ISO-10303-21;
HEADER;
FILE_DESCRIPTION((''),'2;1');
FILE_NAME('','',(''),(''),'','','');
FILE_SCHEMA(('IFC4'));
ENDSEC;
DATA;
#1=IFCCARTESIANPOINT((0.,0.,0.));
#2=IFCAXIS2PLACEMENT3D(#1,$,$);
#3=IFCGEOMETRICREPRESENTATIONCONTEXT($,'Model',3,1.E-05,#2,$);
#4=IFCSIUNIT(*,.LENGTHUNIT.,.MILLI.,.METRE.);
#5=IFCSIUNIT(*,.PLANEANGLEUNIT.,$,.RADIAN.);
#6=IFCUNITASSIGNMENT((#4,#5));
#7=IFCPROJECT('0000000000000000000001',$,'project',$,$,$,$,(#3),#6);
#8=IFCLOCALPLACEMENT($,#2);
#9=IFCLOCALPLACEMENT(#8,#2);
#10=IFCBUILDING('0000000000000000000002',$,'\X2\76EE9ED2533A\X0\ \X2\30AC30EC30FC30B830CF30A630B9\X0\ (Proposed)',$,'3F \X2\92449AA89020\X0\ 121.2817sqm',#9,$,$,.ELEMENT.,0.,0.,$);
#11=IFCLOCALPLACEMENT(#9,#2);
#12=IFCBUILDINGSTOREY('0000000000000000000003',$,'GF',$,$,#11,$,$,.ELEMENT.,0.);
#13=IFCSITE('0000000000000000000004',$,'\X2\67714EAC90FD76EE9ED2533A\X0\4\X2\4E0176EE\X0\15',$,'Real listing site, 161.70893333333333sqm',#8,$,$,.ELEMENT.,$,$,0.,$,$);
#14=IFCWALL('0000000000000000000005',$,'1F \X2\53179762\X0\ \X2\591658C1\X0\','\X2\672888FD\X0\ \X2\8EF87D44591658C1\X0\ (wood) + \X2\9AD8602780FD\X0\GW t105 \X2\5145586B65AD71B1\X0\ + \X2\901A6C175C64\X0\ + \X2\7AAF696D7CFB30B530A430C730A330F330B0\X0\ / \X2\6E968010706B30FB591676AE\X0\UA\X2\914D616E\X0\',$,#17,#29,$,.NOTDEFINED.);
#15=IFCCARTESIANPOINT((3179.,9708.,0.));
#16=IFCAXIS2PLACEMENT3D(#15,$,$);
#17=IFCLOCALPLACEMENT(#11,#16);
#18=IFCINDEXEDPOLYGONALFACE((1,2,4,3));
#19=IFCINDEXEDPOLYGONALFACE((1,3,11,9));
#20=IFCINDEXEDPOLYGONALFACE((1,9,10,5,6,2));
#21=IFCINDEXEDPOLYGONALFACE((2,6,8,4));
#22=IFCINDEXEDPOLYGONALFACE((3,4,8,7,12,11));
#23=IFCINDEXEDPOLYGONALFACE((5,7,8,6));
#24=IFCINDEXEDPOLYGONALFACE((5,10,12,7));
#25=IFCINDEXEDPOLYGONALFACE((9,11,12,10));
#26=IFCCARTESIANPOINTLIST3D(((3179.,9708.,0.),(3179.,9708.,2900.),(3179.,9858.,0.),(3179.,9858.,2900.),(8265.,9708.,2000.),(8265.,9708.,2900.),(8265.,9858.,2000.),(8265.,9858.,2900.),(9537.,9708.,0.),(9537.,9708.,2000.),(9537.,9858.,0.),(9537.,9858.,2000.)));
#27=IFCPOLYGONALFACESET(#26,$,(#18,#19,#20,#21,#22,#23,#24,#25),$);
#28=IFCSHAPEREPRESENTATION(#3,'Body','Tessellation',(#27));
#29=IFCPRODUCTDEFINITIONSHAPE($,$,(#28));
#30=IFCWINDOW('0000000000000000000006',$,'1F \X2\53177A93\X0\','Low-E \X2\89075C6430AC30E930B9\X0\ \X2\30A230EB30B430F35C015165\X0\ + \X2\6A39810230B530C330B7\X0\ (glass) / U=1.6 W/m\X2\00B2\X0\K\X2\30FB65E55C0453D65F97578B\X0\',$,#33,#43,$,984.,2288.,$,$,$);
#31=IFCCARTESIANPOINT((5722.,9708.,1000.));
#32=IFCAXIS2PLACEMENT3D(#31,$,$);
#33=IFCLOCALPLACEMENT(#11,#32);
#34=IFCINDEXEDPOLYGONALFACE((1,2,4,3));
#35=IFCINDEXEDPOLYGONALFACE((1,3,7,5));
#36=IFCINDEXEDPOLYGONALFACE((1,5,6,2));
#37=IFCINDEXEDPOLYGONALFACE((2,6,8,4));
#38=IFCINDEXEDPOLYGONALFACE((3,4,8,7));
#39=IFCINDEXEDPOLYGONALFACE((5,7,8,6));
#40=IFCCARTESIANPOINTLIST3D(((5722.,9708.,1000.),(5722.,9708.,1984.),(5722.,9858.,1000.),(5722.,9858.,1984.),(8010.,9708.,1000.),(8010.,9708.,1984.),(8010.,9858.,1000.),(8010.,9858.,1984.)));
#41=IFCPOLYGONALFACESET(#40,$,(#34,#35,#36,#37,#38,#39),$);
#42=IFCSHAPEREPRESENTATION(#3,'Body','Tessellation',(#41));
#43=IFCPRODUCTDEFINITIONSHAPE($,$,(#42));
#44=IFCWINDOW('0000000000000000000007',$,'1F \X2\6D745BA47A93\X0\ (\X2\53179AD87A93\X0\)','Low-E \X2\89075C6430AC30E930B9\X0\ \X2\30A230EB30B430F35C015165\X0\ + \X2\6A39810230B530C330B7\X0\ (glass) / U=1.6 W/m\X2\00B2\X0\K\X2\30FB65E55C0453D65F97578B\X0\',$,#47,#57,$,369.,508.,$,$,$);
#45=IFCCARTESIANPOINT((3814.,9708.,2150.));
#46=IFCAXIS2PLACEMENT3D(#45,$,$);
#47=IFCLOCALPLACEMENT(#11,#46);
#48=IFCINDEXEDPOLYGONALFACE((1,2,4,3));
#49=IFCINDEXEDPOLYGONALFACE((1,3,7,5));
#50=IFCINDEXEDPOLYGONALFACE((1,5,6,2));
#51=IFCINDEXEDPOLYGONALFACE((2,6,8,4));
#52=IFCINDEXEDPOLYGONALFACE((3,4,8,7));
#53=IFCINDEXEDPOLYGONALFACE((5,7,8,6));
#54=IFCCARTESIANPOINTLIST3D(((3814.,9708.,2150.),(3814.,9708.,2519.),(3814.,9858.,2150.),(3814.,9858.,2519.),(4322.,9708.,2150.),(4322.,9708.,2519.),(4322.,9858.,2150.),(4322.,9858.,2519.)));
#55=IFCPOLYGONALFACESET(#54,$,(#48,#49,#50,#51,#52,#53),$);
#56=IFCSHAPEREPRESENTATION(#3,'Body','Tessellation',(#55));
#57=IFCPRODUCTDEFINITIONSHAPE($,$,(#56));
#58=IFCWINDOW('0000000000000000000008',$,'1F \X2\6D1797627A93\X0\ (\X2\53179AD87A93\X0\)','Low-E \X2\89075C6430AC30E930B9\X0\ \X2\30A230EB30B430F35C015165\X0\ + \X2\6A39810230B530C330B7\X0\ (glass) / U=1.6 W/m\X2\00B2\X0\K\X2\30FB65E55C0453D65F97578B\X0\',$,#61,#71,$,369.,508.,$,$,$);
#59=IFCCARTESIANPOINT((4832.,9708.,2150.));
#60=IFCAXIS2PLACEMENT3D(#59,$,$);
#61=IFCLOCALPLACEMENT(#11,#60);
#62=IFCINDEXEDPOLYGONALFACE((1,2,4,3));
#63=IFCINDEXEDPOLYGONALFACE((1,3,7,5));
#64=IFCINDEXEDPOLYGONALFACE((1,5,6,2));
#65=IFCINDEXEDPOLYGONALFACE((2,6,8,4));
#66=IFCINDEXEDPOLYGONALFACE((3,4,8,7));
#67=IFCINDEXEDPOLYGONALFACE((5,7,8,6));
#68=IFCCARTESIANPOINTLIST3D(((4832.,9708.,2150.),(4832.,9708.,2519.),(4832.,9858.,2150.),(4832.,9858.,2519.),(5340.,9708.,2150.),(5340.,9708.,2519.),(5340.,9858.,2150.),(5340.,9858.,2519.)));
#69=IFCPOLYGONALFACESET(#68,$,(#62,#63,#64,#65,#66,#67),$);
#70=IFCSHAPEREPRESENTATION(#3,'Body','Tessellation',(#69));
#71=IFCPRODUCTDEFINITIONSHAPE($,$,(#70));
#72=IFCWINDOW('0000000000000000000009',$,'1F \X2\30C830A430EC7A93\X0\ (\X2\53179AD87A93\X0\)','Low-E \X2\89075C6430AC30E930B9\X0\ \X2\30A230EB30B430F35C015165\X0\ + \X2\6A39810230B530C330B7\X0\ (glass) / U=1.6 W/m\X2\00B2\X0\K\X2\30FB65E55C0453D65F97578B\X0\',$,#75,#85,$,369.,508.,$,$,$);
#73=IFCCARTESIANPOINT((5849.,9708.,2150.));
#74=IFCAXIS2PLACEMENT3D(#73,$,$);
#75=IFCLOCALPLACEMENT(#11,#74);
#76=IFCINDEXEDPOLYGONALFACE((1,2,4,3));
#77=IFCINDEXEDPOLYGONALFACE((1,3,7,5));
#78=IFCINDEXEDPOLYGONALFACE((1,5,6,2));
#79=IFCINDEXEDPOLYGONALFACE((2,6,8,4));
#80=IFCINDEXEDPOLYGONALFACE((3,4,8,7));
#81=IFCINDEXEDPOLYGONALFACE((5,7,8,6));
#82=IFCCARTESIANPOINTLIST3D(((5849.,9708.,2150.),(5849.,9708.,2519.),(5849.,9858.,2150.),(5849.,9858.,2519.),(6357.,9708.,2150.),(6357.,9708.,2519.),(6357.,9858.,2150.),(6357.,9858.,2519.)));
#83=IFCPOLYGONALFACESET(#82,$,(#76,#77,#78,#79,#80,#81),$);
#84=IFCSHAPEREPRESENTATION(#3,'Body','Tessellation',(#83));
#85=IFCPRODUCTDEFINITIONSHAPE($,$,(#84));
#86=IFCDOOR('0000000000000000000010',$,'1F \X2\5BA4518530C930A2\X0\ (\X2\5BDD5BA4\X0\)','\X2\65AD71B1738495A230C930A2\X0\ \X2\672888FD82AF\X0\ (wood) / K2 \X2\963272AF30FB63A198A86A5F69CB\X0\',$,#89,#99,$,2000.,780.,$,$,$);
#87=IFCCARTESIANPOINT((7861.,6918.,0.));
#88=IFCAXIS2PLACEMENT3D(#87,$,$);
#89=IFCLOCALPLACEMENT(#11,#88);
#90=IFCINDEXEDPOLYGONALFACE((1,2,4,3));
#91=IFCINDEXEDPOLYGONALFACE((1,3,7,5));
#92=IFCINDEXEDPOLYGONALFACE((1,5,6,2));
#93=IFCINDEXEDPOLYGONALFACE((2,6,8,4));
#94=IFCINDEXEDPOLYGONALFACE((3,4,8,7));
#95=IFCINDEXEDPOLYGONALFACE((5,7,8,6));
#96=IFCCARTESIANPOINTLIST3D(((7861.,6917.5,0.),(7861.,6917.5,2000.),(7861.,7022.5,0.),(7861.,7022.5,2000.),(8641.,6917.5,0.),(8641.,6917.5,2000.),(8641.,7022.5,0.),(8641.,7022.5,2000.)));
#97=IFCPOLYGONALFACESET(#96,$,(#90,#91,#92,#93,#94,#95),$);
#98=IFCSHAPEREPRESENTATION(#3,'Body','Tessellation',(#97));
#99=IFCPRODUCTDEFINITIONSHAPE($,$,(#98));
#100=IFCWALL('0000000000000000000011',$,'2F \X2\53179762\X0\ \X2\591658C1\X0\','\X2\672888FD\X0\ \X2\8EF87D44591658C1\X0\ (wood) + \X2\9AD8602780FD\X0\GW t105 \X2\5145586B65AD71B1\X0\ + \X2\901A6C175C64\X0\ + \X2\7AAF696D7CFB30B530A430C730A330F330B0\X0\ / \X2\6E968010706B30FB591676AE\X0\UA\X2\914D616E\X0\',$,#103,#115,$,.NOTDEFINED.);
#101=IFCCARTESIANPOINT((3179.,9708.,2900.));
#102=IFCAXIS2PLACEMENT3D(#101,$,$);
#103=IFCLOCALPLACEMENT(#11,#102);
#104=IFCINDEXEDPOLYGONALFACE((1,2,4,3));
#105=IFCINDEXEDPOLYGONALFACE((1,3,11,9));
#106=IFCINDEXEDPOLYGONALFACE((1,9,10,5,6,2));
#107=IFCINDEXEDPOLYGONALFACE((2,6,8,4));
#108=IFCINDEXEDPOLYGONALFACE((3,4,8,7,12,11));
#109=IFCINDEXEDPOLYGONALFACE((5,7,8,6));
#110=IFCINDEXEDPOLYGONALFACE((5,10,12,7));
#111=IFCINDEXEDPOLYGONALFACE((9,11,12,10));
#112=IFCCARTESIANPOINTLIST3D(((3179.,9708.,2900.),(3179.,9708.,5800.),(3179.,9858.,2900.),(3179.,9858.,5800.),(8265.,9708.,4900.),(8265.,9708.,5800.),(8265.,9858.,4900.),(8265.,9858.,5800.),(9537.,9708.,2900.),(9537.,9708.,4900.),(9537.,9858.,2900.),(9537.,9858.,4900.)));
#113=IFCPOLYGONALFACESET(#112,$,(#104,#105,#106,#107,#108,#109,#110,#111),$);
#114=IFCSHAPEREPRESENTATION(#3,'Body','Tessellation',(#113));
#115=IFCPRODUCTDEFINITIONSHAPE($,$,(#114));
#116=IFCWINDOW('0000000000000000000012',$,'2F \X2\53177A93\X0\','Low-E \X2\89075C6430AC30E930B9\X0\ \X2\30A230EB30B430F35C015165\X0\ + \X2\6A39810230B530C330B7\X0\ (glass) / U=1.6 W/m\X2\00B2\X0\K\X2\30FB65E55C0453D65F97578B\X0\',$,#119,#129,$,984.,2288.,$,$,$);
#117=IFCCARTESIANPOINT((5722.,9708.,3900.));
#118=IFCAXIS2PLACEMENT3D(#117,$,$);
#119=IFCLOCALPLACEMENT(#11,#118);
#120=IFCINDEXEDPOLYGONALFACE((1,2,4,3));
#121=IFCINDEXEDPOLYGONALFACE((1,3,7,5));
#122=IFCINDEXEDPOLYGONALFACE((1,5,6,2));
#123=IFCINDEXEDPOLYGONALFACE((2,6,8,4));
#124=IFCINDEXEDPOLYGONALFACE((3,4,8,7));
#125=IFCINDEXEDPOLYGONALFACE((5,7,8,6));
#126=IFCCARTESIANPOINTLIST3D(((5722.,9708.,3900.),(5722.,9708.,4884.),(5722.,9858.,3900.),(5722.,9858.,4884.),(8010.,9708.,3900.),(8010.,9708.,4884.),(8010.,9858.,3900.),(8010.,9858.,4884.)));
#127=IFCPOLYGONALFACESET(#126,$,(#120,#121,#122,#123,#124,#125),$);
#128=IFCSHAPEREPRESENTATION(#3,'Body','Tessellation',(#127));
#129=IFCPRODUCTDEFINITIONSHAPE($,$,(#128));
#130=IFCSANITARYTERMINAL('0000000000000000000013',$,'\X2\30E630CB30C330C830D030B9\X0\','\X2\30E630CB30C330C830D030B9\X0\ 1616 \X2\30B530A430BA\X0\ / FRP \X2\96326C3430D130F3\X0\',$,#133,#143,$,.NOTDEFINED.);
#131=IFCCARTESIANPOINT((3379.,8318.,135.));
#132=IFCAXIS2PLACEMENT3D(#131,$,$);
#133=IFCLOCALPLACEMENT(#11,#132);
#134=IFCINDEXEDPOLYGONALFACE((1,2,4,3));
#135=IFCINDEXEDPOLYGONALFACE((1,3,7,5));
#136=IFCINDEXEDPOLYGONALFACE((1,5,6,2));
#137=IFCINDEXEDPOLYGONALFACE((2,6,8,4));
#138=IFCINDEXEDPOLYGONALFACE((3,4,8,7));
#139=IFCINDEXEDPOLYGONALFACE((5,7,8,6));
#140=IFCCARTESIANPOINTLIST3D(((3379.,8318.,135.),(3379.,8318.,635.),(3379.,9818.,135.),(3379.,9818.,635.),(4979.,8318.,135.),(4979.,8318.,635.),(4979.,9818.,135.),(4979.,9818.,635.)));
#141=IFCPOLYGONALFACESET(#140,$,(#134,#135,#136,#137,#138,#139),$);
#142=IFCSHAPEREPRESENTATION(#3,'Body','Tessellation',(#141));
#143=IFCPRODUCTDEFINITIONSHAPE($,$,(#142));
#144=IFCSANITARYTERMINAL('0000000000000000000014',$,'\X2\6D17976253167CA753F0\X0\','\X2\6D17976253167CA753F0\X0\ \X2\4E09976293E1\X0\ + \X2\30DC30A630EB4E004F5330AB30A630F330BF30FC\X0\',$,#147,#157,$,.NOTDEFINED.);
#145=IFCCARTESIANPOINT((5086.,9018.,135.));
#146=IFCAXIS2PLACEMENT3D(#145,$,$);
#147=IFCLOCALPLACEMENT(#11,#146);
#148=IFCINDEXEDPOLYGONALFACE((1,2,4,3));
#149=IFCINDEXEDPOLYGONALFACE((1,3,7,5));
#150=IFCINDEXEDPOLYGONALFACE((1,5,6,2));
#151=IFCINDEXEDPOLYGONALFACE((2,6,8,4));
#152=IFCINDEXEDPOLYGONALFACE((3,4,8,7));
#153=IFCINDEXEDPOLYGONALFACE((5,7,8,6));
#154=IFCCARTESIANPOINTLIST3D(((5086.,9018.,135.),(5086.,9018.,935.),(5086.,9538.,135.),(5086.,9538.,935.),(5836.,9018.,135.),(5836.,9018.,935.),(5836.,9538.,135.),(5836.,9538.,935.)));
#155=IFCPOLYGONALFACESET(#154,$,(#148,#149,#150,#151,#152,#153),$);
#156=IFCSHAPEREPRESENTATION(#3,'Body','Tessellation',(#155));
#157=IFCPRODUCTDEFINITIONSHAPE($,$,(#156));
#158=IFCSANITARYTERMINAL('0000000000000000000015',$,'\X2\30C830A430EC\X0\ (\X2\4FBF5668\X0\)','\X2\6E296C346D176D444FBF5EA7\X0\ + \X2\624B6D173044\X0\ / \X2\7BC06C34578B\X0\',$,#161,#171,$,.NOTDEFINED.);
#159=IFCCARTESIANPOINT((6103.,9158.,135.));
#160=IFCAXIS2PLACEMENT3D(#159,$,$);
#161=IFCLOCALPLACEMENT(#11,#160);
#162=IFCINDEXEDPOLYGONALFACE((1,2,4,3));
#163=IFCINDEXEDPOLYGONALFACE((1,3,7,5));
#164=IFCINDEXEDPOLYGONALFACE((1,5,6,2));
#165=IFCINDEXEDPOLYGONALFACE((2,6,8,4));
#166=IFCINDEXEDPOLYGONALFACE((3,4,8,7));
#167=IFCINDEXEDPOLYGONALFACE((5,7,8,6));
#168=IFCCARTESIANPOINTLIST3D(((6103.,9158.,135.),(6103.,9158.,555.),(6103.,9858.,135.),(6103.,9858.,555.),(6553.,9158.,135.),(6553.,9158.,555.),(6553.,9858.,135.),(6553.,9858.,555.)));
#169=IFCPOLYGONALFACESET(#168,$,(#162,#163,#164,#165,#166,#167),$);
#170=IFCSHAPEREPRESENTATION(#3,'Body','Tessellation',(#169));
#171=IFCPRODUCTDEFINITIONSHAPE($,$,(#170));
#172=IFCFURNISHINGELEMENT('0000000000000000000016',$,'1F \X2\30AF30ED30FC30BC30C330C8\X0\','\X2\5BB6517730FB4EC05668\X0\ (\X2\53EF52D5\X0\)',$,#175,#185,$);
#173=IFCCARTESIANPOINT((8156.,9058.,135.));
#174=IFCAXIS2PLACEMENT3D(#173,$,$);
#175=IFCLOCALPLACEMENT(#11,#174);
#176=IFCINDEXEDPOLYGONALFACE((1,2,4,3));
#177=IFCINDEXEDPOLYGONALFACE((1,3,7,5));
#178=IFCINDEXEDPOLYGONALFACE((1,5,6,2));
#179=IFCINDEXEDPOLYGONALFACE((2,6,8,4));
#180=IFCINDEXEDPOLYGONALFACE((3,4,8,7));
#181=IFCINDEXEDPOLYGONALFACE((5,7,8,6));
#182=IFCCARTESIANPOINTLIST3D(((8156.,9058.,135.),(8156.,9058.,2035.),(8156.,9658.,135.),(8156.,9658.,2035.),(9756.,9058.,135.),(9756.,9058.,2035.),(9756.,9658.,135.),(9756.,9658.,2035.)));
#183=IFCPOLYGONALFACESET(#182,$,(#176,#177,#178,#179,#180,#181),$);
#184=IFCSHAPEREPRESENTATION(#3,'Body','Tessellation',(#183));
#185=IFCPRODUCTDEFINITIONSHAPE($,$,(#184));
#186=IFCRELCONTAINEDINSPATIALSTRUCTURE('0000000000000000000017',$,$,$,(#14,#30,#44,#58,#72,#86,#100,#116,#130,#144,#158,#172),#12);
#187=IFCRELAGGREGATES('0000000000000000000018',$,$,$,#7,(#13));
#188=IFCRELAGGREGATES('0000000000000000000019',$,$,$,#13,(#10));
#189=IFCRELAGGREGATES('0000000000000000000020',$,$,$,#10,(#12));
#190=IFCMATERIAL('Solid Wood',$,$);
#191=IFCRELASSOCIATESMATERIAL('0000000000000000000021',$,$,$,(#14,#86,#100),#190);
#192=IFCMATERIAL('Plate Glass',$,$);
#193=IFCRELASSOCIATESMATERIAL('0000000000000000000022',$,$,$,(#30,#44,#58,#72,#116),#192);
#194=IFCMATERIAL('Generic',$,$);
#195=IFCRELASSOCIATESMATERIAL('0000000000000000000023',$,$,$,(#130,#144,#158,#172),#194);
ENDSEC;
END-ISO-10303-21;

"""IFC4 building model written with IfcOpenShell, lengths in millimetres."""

from ifc_helpers import new_model, si_unit, frame, frame_2d, origin, place, context, project, spatial, rectangle, extrude, material, element, fill, save


model = new_model("IFC4")

# Units and contexts
model_context = context("Model", 3, precision=1e-05, world=origin())
ifc_project = project(units=[si_unit("LENGTHUNIT", "METRE", prefix="MILLI"), si_unit("PLANEANGLEUNIT", "RADIAN")], contexts=[model_context])

# Site, building, storey
site_placement = place(None, origin())
site = spatial("IfcSite", under=ifc_project, at=site_placement, Name="東京都目黒区4丁目15", ObjectType="Real listing site, 161.70893333333333sqm", CompositionType="ELEMENT", RefElevation=0.0)
building_placement = place(site_placement, origin())
building = spatial("IfcBuilding", under=site, at=building_placement, Name="目黒区 ガレージハウス (Proposed)", ObjectType="3F 鉄骨造 121.2817sqm", CompositionType="ELEMENT", ElevationOfRefHeight=0.0, ElevationOfTerrain=0.0)
storey_placement = place(building_placement, origin())
storey = spatial("IfcBuildingStorey", under=building, at=storey_placement, Name="GF", CompositionType="ELEMENT", Elevation=0.0)

# Wall, openings, windows
ifc_material_1 = material(Name="Solid Wood")
wall_1_placement = place(storey_placement, frame((3179.0, 9708.0, 0.0)))
wall_1 = element("IfcWall", 1, at=wall_1_placement, inside=storey, material=ifc_material_1, Name="1F 北面 外壁", Description="木製 軸組外壁 (wood) + 高性能GW t105 充填断熱 + 通気層 + 窯業系サイディング / 準耐火・外皮UA配慮", PredefinedType="NOTDEFINED", context=model_context, shape_type="SweptSolid", body=[
    extrude(rectangle(XDim=6358.0, YDim=150.0, at=frame_2d((3179.0, 75.0))), frame((3179.0, 9708.0, 0.0)), (0.0, 0.0, 1.0), 2900.0),
])
opening_1_placement = place(storey_placement, frame((5722.0, 9708.0, 1000.0)))
opening_1 = element("IfcOpeningElement", 2, at=opening_1_placement, cuts=wall_1, PredefinedType="NOTDEFINED", context=model_context, shape_type="SweptSolid", body=[
    extrude(rectangle(XDim=2288.0, YDim=150.0, at=frame_2d((1144.0, 75.0))), frame((5722.0, 9708.0, 1000.0)), (0.0, 0.0, 1.0), 984.0),
])
opening_2_placement = place(storey_placement, frame((3814.0, 9708.0, 2150.0)))
opening_2 = element("IfcOpeningElement", 3, at=opening_2_placement, cuts=wall_1, PredefinedType="NOTDEFINED", context=model_context, shape_type="SweptSolid", body=[
    extrude(rectangle(XDim=508.0, YDim=150.0, at=frame_2d((254.0, 75.0))), frame((3814.0, 9708.0, 2150.0)), (0.0, 0.0, 1.0), 369.0),
])
opening_3_placement = place(storey_placement, frame((4832.0, 9708.0, 2150.0)))
opening_3 = element("IfcOpeningElement", 4, at=opening_3_placement, cuts=wall_1, PredefinedType="NOTDEFINED", context=model_context, shape_type="SweptSolid", body=[
    extrude(rectangle(XDim=508.0, YDim=150.0, at=frame_2d((254.0, 75.0))), frame((4832.0, 9708.0, 2150.0)), (0.0, 0.0, 1.0), 369.0),
])
opening_4_placement = place(storey_placement, frame((5849.0, 9708.0, 2150.0)))
opening_4 = element("IfcOpeningElement", 5, at=opening_4_placement, cuts=wall_1, PredefinedType="NOTDEFINED", context=model_context, shape_type="SweptSolid", body=[
    extrude(rectangle(XDim=508.0, YDim=150.0, at=frame_2d((254.0, 75.0))), frame((5849.0, 9708.0, 2150.0)), (0.0, 0.0, 1.0), 369.0),
])
ifc_material_2 = material(Name="Plate Glass")
window_1_placement = place(storey_placement, frame((5722.0, 9708.0, 1000.0)))
window_1 = element("IfcWindow", 6, at=window_1_placement, inside=storey, material=ifc_material_2, Name="1F 北窓", Description="Low-E 複層ガラス アルゴン封入 + 樹脂サッシ (glass) / U=1.6 W/m²K・日射取得型", OverallHeight=984.0, OverallWidth=2288.0, context=model_context, shape_type="SweptSolid", body=[
    extrude(rectangle(XDim=2288.0, YDim=150.0, at=frame_2d((1144.0, 75.0))), frame((5722.0, 9708.0, 1000.0)), (0.0, 0.0, 1.0), 984.0),
])
fill(opening_1, window_1)
window_2_placement = place(storey_placement, frame((3814.0, 9708.0, 2150.0)))
window_2 = element("IfcWindow", 7, at=window_2_placement, inside=storey, material=ifc_material_2, Name="1F 浴室窓 (北高窓)", Description="Low-E 複層ガラス アルゴン封入 + 樹脂サッシ (glass) / U=1.6 W/m²K・日射取得型", OverallHeight=369.0, OverallWidth=508.0, context=model_context, shape_type="SweptSolid", body=[
    extrude(rectangle(XDim=508.0, YDim=150.0, at=frame_2d((254.0, 75.0))), frame((3814.0, 9708.0, 2150.0)), (0.0, 0.0, 1.0), 369.0),
])
fill(opening_2, window_2)
window_3_placement = place(storey_placement, frame((4832.0, 9708.0, 2150.0)))
window_3 = element("IfcWindow", 8, at=window_3_placement, inside=storey, material=ifc_material_2, Name="1F 洗面窓 (北高窓)", Description="Low-E 複層ガラス アルゴン封入 + 樹脂サッシ (glass) / U=1.6 W/m²K・日射取得型", OverallHeight=369.0, OverallWidth=508.0, context=model_context, shape_type="SweptSolid", body=[
    extrude(rectangle(XDim=508.0, YDim=150.0, at=frame_2d((254.0, 75.0))), frame((4832.0, 9708.0, 2150.0)), (0.0, 0.0, 1.0), 369.0),
])
fill(opening_3, window_3)
window_4_placement = place(storey_placement, frame((5849.0, 9708.0, 2150.0)))
window_4 = element("IfcWindow", 9, at=window_4_placement, inside=storey, material=ifc_material_2, Name="1F トイレ窓 (北高窓)", Description="Low-E 複層ガラス アルゴン封入 + 樹脂サッシ (glass) / U=1.6 W/m²K・日射取得型", OverallHeight=369.0, OverallWidth=508.0, context=model_context, shape_type="SweptSolid", body=[
    extrude(rectangle(XDim=508.0, YDim=150.0, at=frame_2d((254.0, 75.0))), frame((5849.0, 9708.0, 2150.0)), (0.0, 0.0, 1.0), 369.0),
])
fill(opening_4, window_4)

# Door
door_1_placement = place(storey_placement, frame((7861.0, 6918.0, 0.0)))
element("IfcDoor", 10, at=door_1_placement, inside=storey, material=ifc_material_1, Name="1F 室内ドア (寝室)", Description="断熱玄関ドア 木製芯 (wood) / K2 防犯・採風機構", OverallHeight=2000.0, OverallWidth=780.0, context=model_context, shape_type="SweptSolid", body=[
    extrude(rectangle(XDim=780.0, YDim=105.0, at=frame_2d((390.0, 52.0))), frame((7861.0, 6918.0, 0.0)), (0.0, 0.0, 1.0), 2000.0),
])

# Wall, opening, window
wall_2_placement = place(storey_placement, frame((3179.0, 9708.0, 2900.0)))
wall_2 = element("IfcWall", 11, at=wall_2_placement, inside=storey, material=ifc_material_1, Name="2F 北面 外壁", Description="木製 軸組外壁 (wood) + 高性能GW t105 充填断熱 + 通気層 + 窯業系サイディング / 準耐火・外皮UA配慮", PredefinedType="NOTDEFINED", context=model_context, shape_type="SweptSolid", body=[
    extrude(rectangle(XDim=6358.0, YDim=150.0, at=frame_2d((3179.0, 75.0))), frame((3179.0, 9708.0, 2900.0)), (0.0, 0.0, 1.0), 2900.0),
])
opening_5_placement = place(storey_placement, frame((5722.0, 9708.0, 3900.0)))
opening_5 = element("IfcOpeningElement", 12, at=opening_5_placement, cuts=wall_2, PredefinedType="NOTDEFINED", context=model_context, shape_type="SweptSolid", body=[
    extrude(rectangle(XDim=2288.0, YDim=150.0, at=frame_2d((1144.0, 75.0))), frame((5722.0, 9708.0, 3900.0)), (0.0, 0.0, 1.0), 984.0),
])
window_5_placement = place(storey_placement, frame((5722.0, 9708.0, 3900.0)))
window_5 = element("IfcWindow", 13, at=window_5_placement, inside=storey, material=ifc_material_2, Name="2F 北窓", Description="Low-E 複層ガラス アルゴン封入 + 樹脂サッシ (glass) / U=1.6 W/m²K・日射取得型", OverallHeight=984.0, OverallWidth=2288.0, context=model_context, shape_type="SweptSolid", body=[
    extrude(rectangle(XDim=2288.0, YDim=150.0, at=frame_2d((1144.0, 75.0))), frame((5722.0, 9708.0, 3900.0)), (0.0, 0.0, 1.0), 984.0),
])
fill(opening_5, window_5)

# Sanitary terminals
ifc_material_3 = material(Name="Generic")
sanitary_terminal_1_placement = place(storey_placement, frame((3379.0, 8318.0, 135.0)))
element("IfcSanitaryTerminal", 14, at=sanitary_terminal_1_placement, inside=storey, material=ifc_material_3, Name="ユニットバス", Description="ユニットバス 1616 サイズ / FRP 防水パン", PredefinedType="NOTDEFINED", context=model_context, shape_type="SweptSolid", body=[
    extrude(rectangle(XDim=1600.0, YDim=1500.0, at=frame_2d((800.0, 750.0))), frame((3379.0, 8318.0, 135.0)), (0.0, 0.0, 1.0), 500.0),
])
sanitary_terminal_2_placement = place(storey_placement, frame((5086.0, 9018.0, 135.0)))
element("IfcSanitaryTerminal", 15, at=sanitary_terminal_2_placement, inside=storey, material=ifc_material_3, Name="洗面化粧台", Description="洗面化粧台 三面鏡 + ボウル一体カウンター", PredefinedType="NOTDEFINED", context=model_context, shape_type="SweptSolid", body=[
    extrude(rectangle(XDim=750.0, YDim=520.0, at=frame_2d((375.0, 260.0))), frame((5086.0, 9018.0, 135.0)), (0.0, 0.0, 1.0), 800.0),
])
sanitary_terminal_3_placement = place(storey_placement, frame((6103.0, 9158.0, 135.0)))
element("IfcSanitaryTerminal", 16, at=sanitary_terminal_3_placement, inside=storey, material=ifc_material_3, Name="トイレ (便器)", Description="温水洗浄便座 + 手洗い / 節水型", PredefinedType="NOTDEFINED", context=model_context, shape_type="SweptSolid", body=[
    extrude(rectangle(XDim=450.0, YDim=700.0, at=frame_2d((225.0, 350.0))), frame((6103.0, 9158.0, 135.0)), (0.0, 0.0, 1.0), 420.0),
])

# Furnishing element
furnishing_1_placement = place(storey_placement, frame((8156.0, 9058.0, 135.0)))
element("IfcFurnishingElement", 17, at=furnishing_1_placement, inside=storey, material=ifc_material_3, Name="1F クローゼット", Description="家具・什器 (可動)", context=model_context, shape_type="SweptSolid", body=[
    extrude(rectangle(XDim=1600.0, YDim=600.0, at=frame_2d((800.0, 300.0))), frame((8156.0, 9058.0, 135.0)), (0.0, 0.0, 1.0), 1900.0),
])

save(model, "model.ifc")
